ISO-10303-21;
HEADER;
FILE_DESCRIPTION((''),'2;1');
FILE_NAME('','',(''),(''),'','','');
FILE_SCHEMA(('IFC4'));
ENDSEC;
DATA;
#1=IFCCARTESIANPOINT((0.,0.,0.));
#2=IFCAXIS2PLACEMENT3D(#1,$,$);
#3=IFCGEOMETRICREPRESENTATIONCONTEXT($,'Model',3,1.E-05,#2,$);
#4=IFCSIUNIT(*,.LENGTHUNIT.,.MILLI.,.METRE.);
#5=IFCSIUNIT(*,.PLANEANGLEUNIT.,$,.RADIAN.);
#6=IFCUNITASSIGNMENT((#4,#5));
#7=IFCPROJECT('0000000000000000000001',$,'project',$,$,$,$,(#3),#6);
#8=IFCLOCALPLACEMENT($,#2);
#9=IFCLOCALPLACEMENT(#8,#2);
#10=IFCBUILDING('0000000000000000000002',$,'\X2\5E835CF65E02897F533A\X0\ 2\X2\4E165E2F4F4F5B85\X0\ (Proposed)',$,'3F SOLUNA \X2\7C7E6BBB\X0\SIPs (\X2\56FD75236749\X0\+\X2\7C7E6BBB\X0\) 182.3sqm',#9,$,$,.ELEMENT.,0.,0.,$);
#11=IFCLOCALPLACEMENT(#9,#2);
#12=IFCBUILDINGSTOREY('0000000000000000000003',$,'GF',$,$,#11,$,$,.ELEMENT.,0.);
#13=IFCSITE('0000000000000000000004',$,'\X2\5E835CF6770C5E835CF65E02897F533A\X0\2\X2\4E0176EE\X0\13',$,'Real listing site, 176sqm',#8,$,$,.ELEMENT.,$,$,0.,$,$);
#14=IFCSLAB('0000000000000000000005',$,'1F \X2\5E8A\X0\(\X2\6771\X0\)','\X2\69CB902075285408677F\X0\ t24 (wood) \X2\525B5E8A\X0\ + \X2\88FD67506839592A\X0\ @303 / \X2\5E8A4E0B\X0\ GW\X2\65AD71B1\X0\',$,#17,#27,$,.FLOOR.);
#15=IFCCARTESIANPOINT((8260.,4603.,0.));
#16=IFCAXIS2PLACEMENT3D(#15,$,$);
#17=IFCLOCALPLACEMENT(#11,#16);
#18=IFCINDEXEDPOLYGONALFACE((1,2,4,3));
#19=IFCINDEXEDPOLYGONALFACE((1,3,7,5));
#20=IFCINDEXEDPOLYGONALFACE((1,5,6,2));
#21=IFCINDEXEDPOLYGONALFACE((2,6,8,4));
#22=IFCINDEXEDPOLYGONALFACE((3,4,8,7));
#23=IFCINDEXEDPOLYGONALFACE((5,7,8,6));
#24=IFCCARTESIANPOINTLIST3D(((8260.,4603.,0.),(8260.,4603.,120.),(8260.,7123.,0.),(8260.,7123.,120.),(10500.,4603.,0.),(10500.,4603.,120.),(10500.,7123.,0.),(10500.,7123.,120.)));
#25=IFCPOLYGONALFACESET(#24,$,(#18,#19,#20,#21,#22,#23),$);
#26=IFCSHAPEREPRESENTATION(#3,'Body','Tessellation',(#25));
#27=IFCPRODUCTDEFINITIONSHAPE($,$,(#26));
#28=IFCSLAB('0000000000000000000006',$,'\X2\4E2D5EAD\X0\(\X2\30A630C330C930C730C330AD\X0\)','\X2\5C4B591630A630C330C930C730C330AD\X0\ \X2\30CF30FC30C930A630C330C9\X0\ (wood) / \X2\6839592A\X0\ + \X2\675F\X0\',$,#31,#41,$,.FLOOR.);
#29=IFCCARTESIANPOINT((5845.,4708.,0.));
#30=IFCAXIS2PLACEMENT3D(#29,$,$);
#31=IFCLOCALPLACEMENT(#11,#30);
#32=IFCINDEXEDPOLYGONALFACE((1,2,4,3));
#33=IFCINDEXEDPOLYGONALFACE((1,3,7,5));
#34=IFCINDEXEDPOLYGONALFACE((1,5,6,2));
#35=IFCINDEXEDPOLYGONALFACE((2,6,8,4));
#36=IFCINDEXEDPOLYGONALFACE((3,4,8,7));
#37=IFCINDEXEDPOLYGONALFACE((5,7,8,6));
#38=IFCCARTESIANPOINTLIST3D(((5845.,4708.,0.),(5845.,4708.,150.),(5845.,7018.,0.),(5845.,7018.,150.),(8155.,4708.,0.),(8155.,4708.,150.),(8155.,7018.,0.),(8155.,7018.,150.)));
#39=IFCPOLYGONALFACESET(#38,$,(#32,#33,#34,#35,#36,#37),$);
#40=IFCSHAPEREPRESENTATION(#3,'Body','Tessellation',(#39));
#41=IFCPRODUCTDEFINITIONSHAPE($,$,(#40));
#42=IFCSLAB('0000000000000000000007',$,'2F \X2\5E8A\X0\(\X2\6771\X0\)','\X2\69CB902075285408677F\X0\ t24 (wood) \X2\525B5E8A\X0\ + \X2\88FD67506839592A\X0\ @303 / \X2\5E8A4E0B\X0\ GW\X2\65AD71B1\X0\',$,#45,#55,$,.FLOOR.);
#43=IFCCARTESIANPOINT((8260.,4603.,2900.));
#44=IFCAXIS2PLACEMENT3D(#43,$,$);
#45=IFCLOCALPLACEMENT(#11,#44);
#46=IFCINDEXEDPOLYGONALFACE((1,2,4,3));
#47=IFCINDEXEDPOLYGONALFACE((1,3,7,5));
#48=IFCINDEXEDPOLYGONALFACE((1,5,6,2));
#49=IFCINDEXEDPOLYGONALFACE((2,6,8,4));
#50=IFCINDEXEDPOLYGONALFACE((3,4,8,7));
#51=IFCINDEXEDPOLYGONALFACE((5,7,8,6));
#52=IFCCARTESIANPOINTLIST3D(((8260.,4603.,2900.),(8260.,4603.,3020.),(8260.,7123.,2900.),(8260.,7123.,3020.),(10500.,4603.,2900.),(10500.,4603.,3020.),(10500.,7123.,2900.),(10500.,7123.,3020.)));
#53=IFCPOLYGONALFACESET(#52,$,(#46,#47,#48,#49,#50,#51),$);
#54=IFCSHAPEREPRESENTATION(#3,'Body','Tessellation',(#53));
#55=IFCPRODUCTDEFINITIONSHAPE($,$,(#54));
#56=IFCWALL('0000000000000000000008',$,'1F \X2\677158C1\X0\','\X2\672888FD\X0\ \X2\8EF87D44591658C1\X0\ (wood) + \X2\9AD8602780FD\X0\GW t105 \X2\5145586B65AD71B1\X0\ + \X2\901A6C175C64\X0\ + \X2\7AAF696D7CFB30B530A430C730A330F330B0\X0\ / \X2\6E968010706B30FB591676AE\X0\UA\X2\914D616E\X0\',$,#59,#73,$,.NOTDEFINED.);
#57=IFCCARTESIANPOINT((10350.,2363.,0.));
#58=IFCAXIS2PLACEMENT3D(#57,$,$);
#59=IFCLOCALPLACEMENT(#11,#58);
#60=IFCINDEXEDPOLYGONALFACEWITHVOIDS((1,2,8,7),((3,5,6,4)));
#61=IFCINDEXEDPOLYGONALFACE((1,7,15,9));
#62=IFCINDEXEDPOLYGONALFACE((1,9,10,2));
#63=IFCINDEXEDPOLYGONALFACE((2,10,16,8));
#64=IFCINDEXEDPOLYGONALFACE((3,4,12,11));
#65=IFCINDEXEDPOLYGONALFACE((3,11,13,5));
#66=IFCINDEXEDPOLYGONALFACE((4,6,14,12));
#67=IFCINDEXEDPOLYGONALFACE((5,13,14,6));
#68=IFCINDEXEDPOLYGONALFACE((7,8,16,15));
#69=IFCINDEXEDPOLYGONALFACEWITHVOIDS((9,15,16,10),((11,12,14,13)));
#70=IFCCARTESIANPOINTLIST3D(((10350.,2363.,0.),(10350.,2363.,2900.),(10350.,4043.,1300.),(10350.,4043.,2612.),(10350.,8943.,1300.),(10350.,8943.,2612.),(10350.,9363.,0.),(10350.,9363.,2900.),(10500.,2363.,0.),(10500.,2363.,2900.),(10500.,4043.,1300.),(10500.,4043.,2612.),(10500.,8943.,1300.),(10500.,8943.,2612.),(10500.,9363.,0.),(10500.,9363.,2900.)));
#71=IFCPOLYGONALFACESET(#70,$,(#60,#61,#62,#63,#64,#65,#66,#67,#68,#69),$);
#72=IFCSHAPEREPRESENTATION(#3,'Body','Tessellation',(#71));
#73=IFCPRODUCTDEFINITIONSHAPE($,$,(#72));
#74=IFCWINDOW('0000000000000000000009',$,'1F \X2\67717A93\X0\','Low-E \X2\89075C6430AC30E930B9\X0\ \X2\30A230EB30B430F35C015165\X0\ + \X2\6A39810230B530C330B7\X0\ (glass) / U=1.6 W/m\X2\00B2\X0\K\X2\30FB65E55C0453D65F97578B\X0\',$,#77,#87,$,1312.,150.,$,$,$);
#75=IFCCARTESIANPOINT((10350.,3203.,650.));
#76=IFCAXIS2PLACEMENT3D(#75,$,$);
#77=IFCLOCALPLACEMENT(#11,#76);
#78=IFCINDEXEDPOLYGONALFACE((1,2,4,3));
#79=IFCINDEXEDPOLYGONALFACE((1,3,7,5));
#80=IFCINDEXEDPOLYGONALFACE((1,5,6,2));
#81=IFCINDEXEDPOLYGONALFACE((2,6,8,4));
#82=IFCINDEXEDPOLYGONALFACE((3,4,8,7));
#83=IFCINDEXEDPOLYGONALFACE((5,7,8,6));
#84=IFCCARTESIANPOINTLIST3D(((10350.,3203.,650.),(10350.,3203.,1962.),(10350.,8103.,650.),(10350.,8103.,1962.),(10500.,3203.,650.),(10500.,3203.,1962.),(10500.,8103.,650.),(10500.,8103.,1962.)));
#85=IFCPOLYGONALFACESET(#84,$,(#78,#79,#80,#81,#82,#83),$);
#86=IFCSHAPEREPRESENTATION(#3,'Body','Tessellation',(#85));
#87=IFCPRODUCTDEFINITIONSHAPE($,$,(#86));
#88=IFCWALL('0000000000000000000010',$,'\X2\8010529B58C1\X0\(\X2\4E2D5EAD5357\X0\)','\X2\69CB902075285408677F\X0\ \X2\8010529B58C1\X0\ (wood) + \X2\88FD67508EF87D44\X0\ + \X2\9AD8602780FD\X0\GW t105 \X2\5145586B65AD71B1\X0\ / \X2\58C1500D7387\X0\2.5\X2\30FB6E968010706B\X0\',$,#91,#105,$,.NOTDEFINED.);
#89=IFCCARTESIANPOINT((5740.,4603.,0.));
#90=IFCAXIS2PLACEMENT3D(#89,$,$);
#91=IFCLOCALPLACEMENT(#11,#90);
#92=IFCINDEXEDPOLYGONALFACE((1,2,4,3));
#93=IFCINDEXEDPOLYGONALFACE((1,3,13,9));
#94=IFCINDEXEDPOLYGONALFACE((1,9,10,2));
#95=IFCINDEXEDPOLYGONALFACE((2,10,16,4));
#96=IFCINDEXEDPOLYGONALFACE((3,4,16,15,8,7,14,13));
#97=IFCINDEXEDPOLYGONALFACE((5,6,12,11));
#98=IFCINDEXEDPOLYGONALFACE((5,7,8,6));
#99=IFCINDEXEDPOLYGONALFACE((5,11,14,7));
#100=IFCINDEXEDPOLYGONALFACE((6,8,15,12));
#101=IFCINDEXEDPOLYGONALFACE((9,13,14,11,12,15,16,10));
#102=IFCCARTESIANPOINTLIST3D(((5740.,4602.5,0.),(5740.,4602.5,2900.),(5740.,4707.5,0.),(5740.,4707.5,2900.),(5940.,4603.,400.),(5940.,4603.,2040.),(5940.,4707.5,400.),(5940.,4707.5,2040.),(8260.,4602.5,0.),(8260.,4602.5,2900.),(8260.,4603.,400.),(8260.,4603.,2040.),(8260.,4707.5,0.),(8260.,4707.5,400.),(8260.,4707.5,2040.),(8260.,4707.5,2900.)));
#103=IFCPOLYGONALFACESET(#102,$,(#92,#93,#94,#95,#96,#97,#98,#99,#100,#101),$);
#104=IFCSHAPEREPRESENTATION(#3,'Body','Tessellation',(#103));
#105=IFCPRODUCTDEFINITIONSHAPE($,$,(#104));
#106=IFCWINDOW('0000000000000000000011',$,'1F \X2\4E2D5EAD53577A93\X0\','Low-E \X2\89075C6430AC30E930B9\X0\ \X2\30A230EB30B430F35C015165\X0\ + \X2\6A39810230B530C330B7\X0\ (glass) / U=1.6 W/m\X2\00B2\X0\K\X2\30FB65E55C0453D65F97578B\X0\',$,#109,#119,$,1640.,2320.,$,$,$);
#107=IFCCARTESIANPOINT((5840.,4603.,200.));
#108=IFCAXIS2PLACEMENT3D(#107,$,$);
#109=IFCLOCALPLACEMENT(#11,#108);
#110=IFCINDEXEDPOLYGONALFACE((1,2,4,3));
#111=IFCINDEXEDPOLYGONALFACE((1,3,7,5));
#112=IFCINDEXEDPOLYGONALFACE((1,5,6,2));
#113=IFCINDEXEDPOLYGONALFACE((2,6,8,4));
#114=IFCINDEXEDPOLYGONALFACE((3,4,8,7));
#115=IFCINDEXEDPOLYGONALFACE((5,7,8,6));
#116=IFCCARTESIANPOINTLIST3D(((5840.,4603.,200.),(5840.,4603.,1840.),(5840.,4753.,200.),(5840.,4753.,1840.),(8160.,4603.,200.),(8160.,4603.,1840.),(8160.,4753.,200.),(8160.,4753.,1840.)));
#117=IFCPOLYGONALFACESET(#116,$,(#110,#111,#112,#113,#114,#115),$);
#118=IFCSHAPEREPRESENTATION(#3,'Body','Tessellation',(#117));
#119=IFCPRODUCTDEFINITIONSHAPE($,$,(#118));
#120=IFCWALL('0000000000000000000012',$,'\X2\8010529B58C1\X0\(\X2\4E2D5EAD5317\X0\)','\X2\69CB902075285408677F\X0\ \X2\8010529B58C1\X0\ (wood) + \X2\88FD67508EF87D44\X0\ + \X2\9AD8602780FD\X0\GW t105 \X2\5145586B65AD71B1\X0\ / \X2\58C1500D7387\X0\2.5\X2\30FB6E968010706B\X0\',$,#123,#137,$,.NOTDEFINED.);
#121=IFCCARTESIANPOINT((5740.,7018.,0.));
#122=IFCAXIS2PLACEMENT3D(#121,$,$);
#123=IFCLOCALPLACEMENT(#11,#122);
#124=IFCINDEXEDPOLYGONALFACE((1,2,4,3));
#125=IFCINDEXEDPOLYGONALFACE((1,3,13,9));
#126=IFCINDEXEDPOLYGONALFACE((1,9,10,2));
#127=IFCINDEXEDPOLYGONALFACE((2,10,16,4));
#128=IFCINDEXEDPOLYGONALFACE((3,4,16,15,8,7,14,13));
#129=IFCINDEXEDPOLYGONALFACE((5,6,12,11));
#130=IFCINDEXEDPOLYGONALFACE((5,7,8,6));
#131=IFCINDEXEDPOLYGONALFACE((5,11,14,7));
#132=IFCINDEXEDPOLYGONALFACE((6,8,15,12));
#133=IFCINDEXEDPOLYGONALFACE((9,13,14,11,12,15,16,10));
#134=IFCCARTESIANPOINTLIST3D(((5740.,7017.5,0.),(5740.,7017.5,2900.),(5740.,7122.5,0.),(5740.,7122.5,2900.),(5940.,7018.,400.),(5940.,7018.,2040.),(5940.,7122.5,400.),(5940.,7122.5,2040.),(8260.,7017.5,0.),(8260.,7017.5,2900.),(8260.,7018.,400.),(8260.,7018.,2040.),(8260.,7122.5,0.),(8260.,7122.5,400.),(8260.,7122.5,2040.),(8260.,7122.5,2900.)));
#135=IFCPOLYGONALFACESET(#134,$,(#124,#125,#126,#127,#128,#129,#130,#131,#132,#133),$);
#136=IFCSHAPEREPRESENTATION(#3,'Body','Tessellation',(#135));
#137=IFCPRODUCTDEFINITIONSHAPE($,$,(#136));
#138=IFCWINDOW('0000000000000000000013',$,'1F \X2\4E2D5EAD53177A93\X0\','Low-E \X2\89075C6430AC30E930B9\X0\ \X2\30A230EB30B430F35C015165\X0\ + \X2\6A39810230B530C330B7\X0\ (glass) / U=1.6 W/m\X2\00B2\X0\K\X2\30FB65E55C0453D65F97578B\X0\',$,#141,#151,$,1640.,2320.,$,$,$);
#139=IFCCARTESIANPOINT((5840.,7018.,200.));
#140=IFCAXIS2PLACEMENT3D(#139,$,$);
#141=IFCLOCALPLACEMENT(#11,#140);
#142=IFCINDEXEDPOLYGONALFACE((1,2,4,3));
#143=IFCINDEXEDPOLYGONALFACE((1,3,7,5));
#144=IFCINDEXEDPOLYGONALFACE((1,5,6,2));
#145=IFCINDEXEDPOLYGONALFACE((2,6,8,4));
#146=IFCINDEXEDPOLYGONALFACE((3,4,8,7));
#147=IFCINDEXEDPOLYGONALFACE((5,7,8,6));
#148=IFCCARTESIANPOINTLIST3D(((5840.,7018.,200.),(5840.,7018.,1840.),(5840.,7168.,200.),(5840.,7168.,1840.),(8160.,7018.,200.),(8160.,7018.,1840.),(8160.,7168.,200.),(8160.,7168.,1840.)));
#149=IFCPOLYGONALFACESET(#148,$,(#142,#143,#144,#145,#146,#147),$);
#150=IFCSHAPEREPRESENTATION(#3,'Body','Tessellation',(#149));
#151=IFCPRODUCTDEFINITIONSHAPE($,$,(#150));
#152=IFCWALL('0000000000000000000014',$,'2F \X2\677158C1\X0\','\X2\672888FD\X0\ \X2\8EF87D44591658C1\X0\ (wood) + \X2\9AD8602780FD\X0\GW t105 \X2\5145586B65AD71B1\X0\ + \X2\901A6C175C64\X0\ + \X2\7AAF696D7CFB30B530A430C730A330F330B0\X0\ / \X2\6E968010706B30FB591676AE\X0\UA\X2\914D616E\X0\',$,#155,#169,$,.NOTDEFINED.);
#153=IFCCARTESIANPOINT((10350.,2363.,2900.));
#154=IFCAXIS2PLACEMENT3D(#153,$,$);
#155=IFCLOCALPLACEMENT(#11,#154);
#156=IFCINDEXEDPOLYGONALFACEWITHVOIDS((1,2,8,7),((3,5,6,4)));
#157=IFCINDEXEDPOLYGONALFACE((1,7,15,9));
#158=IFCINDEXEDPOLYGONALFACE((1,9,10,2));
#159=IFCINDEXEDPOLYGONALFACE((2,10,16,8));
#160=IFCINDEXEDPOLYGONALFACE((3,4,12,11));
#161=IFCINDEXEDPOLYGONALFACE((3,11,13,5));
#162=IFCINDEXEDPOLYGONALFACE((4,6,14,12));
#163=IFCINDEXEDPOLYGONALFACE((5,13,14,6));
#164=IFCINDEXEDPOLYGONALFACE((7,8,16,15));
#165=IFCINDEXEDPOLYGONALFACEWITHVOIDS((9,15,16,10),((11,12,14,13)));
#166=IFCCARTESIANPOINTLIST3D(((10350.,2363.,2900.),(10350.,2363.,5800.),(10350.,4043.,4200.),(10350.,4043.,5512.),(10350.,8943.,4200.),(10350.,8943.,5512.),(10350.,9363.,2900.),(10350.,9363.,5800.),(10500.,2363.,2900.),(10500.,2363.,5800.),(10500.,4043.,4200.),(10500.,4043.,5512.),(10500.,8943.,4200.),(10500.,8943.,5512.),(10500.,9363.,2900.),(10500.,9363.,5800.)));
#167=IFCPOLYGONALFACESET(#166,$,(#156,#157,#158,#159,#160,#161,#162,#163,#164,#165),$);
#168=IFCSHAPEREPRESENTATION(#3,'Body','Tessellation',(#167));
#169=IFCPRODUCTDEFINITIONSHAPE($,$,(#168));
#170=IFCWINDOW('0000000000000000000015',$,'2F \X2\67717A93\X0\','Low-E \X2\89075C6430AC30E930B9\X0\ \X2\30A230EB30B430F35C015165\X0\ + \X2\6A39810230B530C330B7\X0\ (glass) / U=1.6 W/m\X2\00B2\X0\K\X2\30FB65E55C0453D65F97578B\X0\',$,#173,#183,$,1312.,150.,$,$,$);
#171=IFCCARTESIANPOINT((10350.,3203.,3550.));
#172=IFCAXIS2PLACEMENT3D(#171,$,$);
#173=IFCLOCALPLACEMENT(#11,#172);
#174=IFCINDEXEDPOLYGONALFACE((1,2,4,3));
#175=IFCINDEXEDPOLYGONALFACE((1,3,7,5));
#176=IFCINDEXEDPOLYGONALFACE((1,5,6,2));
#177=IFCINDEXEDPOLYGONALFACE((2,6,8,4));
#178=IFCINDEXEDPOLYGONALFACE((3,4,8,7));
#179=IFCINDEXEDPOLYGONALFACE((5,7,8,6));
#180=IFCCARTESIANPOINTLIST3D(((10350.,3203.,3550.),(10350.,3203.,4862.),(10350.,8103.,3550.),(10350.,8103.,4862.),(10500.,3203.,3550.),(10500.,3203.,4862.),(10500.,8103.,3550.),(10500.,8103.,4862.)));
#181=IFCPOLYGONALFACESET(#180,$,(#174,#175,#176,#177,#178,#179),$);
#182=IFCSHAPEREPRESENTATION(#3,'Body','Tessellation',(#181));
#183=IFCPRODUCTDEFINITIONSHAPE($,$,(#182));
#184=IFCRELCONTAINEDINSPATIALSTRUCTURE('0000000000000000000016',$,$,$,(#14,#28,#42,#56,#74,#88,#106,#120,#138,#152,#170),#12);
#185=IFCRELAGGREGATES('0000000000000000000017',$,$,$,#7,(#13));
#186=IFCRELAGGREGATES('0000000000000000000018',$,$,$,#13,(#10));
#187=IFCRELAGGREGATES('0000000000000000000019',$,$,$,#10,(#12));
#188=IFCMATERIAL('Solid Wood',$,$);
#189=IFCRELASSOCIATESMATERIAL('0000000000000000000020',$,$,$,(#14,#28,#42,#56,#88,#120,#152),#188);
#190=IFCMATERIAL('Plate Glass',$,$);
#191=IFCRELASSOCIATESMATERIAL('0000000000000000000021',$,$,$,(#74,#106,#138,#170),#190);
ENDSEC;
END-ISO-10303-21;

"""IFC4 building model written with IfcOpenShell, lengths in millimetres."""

from ifc_helpers import new_model, si_unit, frame, frame_2d, origin, place, context, project, spatial, rectangle, extrude, material, element, fill, save


model = new_model("IFC4")

# Units and contexts
model_context = context("Model", 3, precision=1e-05, world=origin())
ifc_project = project(units=[si_unit("LENGTHUNIT", "METRE", prefix="MILLI"), si_unit("PLANEANGLEUNIT", "RADIAN")], contexts=[model_context])

# Site, building, storey
site_placement = place(None, origin())
site = spatial("IfcSite", under=ifc_project, at=site_placement, Name="広島県広島市西区2丁目13", ObjectType="Real listing site, 176sqm", CompositionType="ELEMENT", RefElevation=0.0)
building_placement = place(site_placement, origin())
building = spatial("IfcBuilding", under=site, at=building_placement, Name="広島市西区 2世帯住宅 (Proposed)", ObjectType="3F SOLUNA 籾殻SIPs (国産杉+籾殻) 182.3sqm", CompositionType="ELEMENT", ElevationOfRefHeight=0.0, ElevationOfTerrain=0.0)
storey_placement = place(building_placement, origin())
storey = spatial("IfcBuildingStorey", under=building, at=storey_placement, Name="GF", CompositionType="ELEMENT", Elevation=0.0)

# Slabs
ifc_material_1 = material(Name="Solid Wood")
slab_1_placement = place(storey_placement, frame((8260.0, 4603.0, 0.0)))
element("IfcSlab", 1, at=slab_1_placement, inside=storey, material=ifc_material_1, Name="1F 床(東)", Description="構造用合板 t24 (wood) 剛床 + 製材根太 @303 / 床下 GW断熱", PredefinedType="FLOOR", context=model_context, shape_type="SweptSolid", body=[
    extrude(rectangle(XDim=2240.0, YDim=2520.0, at=frame_2d((1120.0, 1260.0))), frame((8260.0, 4603.0, 0.0)), (0.0, 0.0, 1.0), 120.0),
])
slab_2_placement = place(storey_placement, frame((5845.0, 4708.0, 0.0)))
element("IfcSlab", 2, at=slab_2_placement, inside=storey, material=ifc_material_1, Name="中庭(ウッドデッキ)", Description="屋外ウッドデッキ ハードウッド (wood) / 根太 + 束", PredefinedType="FLOOR", context=model_context, shape_type="SweptSolid", body=[
    extrude(rectangle(XDim=2310.0, YDim=2310.0, at=frame_2d((1155.0, 1155.0))), frame((5845.0, 4708.0, 0.0)), (0.0, 0.0, 1.0), 150.0),
])
slab_3_placement = place(storey_placement, frame((8260.0, 4603.0, 2900.0)))
element("IfcSlab", 3, at=slab_3_placement, inside=storey, material=ifc_material_1, Name="2F 床(東)", Description="構造用合板 t24 (wood) 剛床 + 製材根太 @303 / 床下 GW断熱", PredefinedType="FLOOR", context=model_context, shape_type="SweptSolid", body=[
    extrude(rectangle(XDim=2240.0, YDim=2520.0, at=frame_2d((1120.0, 1260.0))), frame((8260.0, 4603.0, 2900.0)), (0.0, 0.0, 1.0), 120.0),
])

# Walls, openings, windows
wall_1_placement = place(storey_placement, frame((10350.0, 2363.0, 0.0)))
wall_1 = element("IfcWall", 4, at=wall_1_placement, inside=storey, material=ifc_material_1, Name="1F 東壁", Description="木製 軸組外壁 (wood) + 高性能GW t105 充填断熱 + 通気層 + 窯業系サイディング / 準耐火・外皮UA配慮", PredefinedType="NOTDEFINED", context=model_context, shape_type="SweptSolid", body=[
    extrude(rectangle(XDim=150.0, YDim=7000.0, at=frame_2d((75.0, 3500.0))), frame((10350.0, 2363.0, 0.0)), (0.0, 0.0, 1.0), 2900.0),
])
opening_1_placement = place(storey_placement, frame((10350.0, 3203.0, 650.0)))
opening_1 = element("IfcOpeningElement", 5, at=opening_1_placement, cuts=wall_1, PredefinedType="NOTDEFINED", context=model_context, shape_type="SweptSolid", body=[
    extrude(rectangle(XDim=150.0, YDim=4900.0, at=frame_2d((75.0, 2450.0))), frame((10350.0, 3203.0, 650.0)), (0.0, 0.0, 1.0), 1312.0),
])
ifc_material_2 = material(Name="Plate Glass")
window_1_placement = place(storey_placement, frame((10350.0, 3203.0, 650.0)))
window_1 = element("IfcWindow", 6, at=window_1_placement, inside=storey, material=ifc_material_2, Name="1F 東窓", Description="Low-E 複層ガラス アルゴン封入 + 樹脂サッシ (glass) / U=1.6 W/m²K・日射取得型", OverallHeight=1312.0, OverallWidth=150.0, context=model_context, shape_type="SweptSolid", body=[
    extrude(rectangle(XDim=150.0, YDim=4900.0, at=frame_2d((75.0, 2450.0))), frame((10350.0, 3203.0, 650.0)), (0.0, 0.0, 1.0), 1312.0),
])
fill(opening_1, window_1)
wall_2_placement = place(storey_placement, frame((5740.0, 4603.0, 0.0)))
wall_2 = element("IfcWall", 7, at=wall_2_placement, inside=storey, material=ifc_material_1, Name="耐力壁(中庭南)", Description="構造用合板 耐力壁 (wood) + 製材軸組 + 高性能GW t105 充填断熱 / 壁倍率2.5・準耐火", PredefinedType="NOTDEFINED", context=model_context, shape_type="SweptSolid", body=[
    extrude(rectangle(XDim=2520.0, YDim=105.0, at=frame_2d((1260.0, 52.0))), frame((5740.0, 4603.0, 0.0)), (0.0, 0.0, 1.0), 2900.0),
])
opening_2_placement = place(storey_placement, frame((5840.0, 4603.0, 200.0)))
opening_2 = element("IfcOpeningElement", 8, at=opening_2_placement, cuts=wall_2, PredefinedType="NOTDEFINED", context=model_context, shape_type="SweptSolid", body=[
    extrude(rectangle(XDim=2320.0, YDim=150.0, at=frame_2d((1160.0, 75.0))), frame((5840.0, 4603.0, 200.0)), (0.0, 0.0, 1.0), 1640.0),
])
window_2_placement = place(storey_placement, frame((5840.0, 4603.0, 200.0)))
window_2 = element("IfcWindow", 9, at=window_2_placement, inside=storey, material=ifc_material_2, Name="1F 中庭南窓", Description="Low-E 複層ガラス アルゴン封入 + 樹脂サッシ (glass) / U=1.6 W/m²K・日射取得型", OverallHeight=1640.0, OverallWidth=2320.0, context=model_context, shape_type="SweptSolid", body=[
    extrude(rectangle(XDim=2320.0, YDim=150.0, at=frame_2d((1160.0, 75.0))), frame((5840.0, 4603.0, 200.0)), (0.0, 0.0, 1.0), 1640.0),
])
fill(opening_2, window_2)
wall_3_placement = place(storey_placement, frame((5740.0, 7018.0, 0.0)))
wall_3 = element("IfcWall", 10, at=wall_3_placement, inside=storey, material=ifc_material_1, Name="耐力壁(中庭北)", Description="構造用合板 耐力壁 (wood) + 製材軸組 + 高性能GW t105 充填断熱 / 壁倍率2.5・準耐火", PredefinedType="NOTDEFINED", context=model_context, shape_type="SweptSolid", body=[
    extrude(rectangle(XDim=2520.0, YDim=105.0, at=frame_2d((1260.0, 52.0))), frame((5740.0, 7018.0, 0.0)), (0.0, 0.0, 1.0), 2900.0),
])
opening_3_placement = place(storey_placement, frame((5840.0, 7018.0, 200.0)))
opening_3 = element("IfcOpeningElement", 11, at=opening_3_placement, cuts=wall_3, PredefinedType="NOTDEFINED", context=model_context, shape_type="SweptSolid", body=[
    extrude(rectangle(XDim=2320.0, YDim=150.0, at=frame_2d((1160.0, 75.0))), frame((5840.0, 7018.0, 200.0)), (0.0, 0.0, 1.0), 1640.0),
])
window_3_placement = place(storey_placement, frame((5840.0, 7018.0, 200.0)))
window_3 = element("IfcWindow", 12, at=window_3_placement, inside=storey, material=ifc_material_2, Name="1F 中庭北窓", Description="Low-E 複層ガラス アルゴン封入 + 樹脂サッシ (glass) / U=1.6 W/m²K・日射取得型", OverallHeight=1640.0, OverallWidth=2320.0, context=model_context, shape_type="SweptSolid", body=[
    extrude(rectangle(XDim=2320.0, YDim=150.0, at=frame_2d((1160.0, 75.0))), frame((5840.0, 7018.0, 200.0)), (0.0, 0.0, 1.0), 1640.0),
])
fill(opening_3, window_3)

# Wall, opening, window
wall_4_placement = place(storey_placement, frame((10350.0, 2363.0, 2900.0)))
wall_4 = element("IfcWall", 13, at=wall_4_placement, inside=storey, material=ifc_material_1, Name="2F 東壁", Description="木製 軸組外壁 (wood) + 高性能GW t105 充填断熱 + 通気層 + 窯業系サイディング / 準耐火・外皮UA配慮", PredefinedType="NOTDEFINED", context=model_context, shape_type="SweptSolid", body=[
    extrude(rectangle(XDim=150.0, YDim=7000.0, at=frame_2d((75.0, 3500.0))), frame((10350.0, 2363.0, 2900.0)), (0.0, 0.0, 1.0), 2900.0),
])
opening_4_placement = place(storey_placement, frame((10350.0, 3203.0, 3550.0)))
opening_4 = element("IfcOpeningElement", 14, at=opening_4_placement, cuts=wall_4, PredefinedType="NOTDEFINED", context=model_context, shape_type="SweptSolid", body=[
    extrude(rectangle(XDim=150.0, YDim=4900.0, at=frame_2d((75.0, 2450.0))), frame((10350.0, 3203.0, 3550.0)), (0.0, 0.0, 1.0), 1312.0),
])
window_4_placement = place(storey_placement, frame((10350.0, 3203.0, 3550.0)))
window_4 = element("IfcWindow", 15, at=window_4_placement, inside=storey, material=ifc_material_2, Name="2F 東窓", Description="Low-E 複層ガラス アルゴン封入 + 樹脂サッシ (glass) / U=1.6 W/m²K・日射取得型", OverallHeight=1312.0, OverallWidth=150.0, context=model_context, shape_type="SweptSolid", body=[
    extrude(rectangle(XDim=150.0, YDim=4900.0, at=frame_2d((75.0, 2450.0))), frame((10350.0, 3203.0, 3550.0)), (0.0, 0.0, 1.0), 1312.0),
])
fill(opening_4, window_4)

save(model, "model.ifc")
